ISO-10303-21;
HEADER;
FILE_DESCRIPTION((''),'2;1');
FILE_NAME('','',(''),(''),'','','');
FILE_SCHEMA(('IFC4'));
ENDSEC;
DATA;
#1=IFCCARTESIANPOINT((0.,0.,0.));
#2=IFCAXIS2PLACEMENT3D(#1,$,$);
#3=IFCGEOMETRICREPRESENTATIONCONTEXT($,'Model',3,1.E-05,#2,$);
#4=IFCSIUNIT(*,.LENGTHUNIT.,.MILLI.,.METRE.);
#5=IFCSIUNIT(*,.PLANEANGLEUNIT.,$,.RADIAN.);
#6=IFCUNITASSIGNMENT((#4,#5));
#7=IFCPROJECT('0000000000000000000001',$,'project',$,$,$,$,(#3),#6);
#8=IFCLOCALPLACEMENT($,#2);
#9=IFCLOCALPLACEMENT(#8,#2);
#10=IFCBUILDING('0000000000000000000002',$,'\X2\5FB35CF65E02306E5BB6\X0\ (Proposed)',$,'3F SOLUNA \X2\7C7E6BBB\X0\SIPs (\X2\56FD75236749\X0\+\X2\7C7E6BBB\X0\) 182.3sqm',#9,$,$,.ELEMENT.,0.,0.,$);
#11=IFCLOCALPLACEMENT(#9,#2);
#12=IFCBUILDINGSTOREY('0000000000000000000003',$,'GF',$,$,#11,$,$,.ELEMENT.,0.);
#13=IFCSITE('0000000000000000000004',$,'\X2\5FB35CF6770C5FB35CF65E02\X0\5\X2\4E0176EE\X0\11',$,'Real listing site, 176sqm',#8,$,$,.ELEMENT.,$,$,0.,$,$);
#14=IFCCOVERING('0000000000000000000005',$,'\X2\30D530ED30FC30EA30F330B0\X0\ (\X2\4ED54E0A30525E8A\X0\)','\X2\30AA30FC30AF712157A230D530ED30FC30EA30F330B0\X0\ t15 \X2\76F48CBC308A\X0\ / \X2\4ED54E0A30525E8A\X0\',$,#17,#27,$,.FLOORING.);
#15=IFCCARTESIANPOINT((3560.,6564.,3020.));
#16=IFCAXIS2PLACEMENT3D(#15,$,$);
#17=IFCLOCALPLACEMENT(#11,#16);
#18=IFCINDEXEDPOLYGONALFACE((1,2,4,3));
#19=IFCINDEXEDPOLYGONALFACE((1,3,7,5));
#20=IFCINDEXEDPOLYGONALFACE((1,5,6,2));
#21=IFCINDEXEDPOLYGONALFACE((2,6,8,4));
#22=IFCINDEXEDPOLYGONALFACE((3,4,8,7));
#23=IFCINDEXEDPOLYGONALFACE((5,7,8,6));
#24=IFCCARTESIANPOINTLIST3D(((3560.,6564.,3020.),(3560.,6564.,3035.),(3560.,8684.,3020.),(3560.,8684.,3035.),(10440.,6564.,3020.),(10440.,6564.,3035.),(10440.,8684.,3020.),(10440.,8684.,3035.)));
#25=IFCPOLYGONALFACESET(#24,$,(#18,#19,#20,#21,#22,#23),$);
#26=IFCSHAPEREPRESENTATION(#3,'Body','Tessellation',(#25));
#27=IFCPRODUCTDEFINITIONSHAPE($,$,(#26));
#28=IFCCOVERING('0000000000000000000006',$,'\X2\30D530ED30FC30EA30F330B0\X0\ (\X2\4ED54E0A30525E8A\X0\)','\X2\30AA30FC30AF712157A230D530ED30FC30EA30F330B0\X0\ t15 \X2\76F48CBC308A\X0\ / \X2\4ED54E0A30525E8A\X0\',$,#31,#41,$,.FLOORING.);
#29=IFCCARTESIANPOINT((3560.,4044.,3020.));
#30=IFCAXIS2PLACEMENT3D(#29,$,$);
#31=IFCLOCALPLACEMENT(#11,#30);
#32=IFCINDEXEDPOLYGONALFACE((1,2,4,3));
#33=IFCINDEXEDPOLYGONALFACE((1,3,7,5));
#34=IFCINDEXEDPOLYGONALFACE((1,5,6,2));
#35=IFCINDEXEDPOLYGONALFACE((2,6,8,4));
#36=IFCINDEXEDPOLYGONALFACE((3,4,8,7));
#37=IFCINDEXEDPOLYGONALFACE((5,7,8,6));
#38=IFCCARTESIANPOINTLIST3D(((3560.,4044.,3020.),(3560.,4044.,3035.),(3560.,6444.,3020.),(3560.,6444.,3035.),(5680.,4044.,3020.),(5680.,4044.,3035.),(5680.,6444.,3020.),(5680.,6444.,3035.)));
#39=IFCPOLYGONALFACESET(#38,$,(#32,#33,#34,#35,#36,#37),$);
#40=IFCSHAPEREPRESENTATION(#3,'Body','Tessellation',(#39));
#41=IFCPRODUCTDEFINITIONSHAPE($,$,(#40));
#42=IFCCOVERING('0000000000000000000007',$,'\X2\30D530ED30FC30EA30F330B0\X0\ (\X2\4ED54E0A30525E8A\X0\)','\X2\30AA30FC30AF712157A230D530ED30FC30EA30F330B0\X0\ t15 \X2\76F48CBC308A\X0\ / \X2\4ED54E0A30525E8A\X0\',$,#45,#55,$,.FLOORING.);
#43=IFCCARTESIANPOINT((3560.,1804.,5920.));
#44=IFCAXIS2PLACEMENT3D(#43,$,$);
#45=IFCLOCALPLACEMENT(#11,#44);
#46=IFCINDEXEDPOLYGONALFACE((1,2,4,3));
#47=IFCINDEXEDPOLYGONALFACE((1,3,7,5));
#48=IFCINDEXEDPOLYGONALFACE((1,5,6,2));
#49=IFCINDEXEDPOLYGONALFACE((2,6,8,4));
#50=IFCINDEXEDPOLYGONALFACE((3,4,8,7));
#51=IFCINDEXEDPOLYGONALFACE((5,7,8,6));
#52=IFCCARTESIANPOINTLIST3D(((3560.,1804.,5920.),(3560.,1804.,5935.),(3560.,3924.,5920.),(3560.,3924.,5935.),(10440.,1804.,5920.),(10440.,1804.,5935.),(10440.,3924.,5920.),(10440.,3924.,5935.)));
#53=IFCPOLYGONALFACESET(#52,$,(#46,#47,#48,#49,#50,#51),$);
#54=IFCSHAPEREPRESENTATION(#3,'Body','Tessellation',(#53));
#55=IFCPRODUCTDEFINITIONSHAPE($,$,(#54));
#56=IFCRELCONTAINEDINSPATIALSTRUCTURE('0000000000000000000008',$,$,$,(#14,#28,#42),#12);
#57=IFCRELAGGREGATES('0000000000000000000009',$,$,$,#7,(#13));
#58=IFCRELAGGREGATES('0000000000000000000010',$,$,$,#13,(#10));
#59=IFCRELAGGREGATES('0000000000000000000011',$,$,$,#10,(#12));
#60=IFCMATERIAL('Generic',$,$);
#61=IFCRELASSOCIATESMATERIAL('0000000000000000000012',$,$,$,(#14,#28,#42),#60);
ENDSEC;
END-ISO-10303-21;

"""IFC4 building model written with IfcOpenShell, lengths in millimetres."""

from ifc_helpers import new_model, si_unit, frame, frame_2d, origin, place, context, project, spatial, rectangle, extrude, material, element, save


model = new_model("IFC4")

# Units and contexts
model_context = context("Model", 3, precision=1e-05, world=origin())
ifc_project = project(units=[si_unit("LENGTHUNIT", "METRE", prefix="MILLI"), si_unit("PLANEANGLEUNIT", "RADIAN")], contexts=[model_context])

# Site, building, storey
site_placement = place(None, origin())
site = spatial("IfcSite", under=ifc_project, at=site_placement, Name="徳島県徳島市5丁目11", ObjectType="Real listing site, 176sqm", CompositionType="ELEMENT", RefElevation=0.0)
building_placement = place(site_placement, origin())
building = spatial("IfcBuilding", under=site, at=building_placement, Name="徳島市の家 (Proposed)", ObjectType="3F SOLUNA 籾殻SIPs (国産杉+籾殻) 182.3sqm", CompositionType="ELEMENT", ElevationOfRefHeight=0.0, ElevationOfTerrain=0.0)
storey_placement = place(building_placement, origin())
storey = spatial("IfcBuildingStorey", under=building, at=storey_placement, Name="GF", CompositionType="ELEMENT", Elevation=0.0)

# Shared definitions
ifc_material_1 = material(Name="Generic")

# Coverings
covering_1_placement = place(storey_placement, frame((3560.0, 6564.0, 3020.0)))
element("IfcCovering", 1, at=covering_1_placement, inside=storey, material=ifc_material_1, Name="フローリング (仕上げ床)", Description="オーク無垢フローリング t15 直貼り / 仕上げ床", PredefinedType="FLOORING", context=model_context, shape_type="SweptSolid", body=[
    extrude(rectangle(XDim=6880.0, YDim=2120.0, at=frame_2d((3440.0, 1060.0))), frame((3560.0, 6564.0, 3020.0)), (0.0, 0.0, 1.0), 15.0),
])
covering_2_placement = place(storey_placement, frame((3560.0, 4044.0, 3020.0)))
element("IfcCovering", 2, at=covering_2_placement, inside=storey, material=ifc_material_1, Name="フローリング (仕上げ床)", Description="オーク無垢フローリング t15 直貼り / 仕上げ床", PredefinedType="FLOORING", context=model_context, shape_type="SweptSolid", body=[
    extrude(rectangle(XDim=2120.0, YDim=2400.0, at=frame_2d((1060.0, 1200.0))), frame((3560.0, 4044.0, 3020.0)), (0.0, 0.0, 1.0), 15.0),
])
covering_3_placement = place(storey_placement, frame((3560.0, 1804.0, 5920.0)))
element("IfcCovering", 3, at=covering_3_placement, inside=storey, material=ifc_material_1, Name="フローリング (仕上げ床)", Description="オーク無垢フローリング t15 直貼り / 仕上げ床", PredefinedType="FLOORING", context=model_context, shape_type="SweptSolid", body=[
    extrude(rectangle(XDim=6880.0, YDim=2120.0, at=frame_2d((3440.0, 1060.0))), frame((3560.0, 1804.0, 5920.0)), (0.0, 0.0, 1.0), 15.0),
])

save(model, "model.ifc")
